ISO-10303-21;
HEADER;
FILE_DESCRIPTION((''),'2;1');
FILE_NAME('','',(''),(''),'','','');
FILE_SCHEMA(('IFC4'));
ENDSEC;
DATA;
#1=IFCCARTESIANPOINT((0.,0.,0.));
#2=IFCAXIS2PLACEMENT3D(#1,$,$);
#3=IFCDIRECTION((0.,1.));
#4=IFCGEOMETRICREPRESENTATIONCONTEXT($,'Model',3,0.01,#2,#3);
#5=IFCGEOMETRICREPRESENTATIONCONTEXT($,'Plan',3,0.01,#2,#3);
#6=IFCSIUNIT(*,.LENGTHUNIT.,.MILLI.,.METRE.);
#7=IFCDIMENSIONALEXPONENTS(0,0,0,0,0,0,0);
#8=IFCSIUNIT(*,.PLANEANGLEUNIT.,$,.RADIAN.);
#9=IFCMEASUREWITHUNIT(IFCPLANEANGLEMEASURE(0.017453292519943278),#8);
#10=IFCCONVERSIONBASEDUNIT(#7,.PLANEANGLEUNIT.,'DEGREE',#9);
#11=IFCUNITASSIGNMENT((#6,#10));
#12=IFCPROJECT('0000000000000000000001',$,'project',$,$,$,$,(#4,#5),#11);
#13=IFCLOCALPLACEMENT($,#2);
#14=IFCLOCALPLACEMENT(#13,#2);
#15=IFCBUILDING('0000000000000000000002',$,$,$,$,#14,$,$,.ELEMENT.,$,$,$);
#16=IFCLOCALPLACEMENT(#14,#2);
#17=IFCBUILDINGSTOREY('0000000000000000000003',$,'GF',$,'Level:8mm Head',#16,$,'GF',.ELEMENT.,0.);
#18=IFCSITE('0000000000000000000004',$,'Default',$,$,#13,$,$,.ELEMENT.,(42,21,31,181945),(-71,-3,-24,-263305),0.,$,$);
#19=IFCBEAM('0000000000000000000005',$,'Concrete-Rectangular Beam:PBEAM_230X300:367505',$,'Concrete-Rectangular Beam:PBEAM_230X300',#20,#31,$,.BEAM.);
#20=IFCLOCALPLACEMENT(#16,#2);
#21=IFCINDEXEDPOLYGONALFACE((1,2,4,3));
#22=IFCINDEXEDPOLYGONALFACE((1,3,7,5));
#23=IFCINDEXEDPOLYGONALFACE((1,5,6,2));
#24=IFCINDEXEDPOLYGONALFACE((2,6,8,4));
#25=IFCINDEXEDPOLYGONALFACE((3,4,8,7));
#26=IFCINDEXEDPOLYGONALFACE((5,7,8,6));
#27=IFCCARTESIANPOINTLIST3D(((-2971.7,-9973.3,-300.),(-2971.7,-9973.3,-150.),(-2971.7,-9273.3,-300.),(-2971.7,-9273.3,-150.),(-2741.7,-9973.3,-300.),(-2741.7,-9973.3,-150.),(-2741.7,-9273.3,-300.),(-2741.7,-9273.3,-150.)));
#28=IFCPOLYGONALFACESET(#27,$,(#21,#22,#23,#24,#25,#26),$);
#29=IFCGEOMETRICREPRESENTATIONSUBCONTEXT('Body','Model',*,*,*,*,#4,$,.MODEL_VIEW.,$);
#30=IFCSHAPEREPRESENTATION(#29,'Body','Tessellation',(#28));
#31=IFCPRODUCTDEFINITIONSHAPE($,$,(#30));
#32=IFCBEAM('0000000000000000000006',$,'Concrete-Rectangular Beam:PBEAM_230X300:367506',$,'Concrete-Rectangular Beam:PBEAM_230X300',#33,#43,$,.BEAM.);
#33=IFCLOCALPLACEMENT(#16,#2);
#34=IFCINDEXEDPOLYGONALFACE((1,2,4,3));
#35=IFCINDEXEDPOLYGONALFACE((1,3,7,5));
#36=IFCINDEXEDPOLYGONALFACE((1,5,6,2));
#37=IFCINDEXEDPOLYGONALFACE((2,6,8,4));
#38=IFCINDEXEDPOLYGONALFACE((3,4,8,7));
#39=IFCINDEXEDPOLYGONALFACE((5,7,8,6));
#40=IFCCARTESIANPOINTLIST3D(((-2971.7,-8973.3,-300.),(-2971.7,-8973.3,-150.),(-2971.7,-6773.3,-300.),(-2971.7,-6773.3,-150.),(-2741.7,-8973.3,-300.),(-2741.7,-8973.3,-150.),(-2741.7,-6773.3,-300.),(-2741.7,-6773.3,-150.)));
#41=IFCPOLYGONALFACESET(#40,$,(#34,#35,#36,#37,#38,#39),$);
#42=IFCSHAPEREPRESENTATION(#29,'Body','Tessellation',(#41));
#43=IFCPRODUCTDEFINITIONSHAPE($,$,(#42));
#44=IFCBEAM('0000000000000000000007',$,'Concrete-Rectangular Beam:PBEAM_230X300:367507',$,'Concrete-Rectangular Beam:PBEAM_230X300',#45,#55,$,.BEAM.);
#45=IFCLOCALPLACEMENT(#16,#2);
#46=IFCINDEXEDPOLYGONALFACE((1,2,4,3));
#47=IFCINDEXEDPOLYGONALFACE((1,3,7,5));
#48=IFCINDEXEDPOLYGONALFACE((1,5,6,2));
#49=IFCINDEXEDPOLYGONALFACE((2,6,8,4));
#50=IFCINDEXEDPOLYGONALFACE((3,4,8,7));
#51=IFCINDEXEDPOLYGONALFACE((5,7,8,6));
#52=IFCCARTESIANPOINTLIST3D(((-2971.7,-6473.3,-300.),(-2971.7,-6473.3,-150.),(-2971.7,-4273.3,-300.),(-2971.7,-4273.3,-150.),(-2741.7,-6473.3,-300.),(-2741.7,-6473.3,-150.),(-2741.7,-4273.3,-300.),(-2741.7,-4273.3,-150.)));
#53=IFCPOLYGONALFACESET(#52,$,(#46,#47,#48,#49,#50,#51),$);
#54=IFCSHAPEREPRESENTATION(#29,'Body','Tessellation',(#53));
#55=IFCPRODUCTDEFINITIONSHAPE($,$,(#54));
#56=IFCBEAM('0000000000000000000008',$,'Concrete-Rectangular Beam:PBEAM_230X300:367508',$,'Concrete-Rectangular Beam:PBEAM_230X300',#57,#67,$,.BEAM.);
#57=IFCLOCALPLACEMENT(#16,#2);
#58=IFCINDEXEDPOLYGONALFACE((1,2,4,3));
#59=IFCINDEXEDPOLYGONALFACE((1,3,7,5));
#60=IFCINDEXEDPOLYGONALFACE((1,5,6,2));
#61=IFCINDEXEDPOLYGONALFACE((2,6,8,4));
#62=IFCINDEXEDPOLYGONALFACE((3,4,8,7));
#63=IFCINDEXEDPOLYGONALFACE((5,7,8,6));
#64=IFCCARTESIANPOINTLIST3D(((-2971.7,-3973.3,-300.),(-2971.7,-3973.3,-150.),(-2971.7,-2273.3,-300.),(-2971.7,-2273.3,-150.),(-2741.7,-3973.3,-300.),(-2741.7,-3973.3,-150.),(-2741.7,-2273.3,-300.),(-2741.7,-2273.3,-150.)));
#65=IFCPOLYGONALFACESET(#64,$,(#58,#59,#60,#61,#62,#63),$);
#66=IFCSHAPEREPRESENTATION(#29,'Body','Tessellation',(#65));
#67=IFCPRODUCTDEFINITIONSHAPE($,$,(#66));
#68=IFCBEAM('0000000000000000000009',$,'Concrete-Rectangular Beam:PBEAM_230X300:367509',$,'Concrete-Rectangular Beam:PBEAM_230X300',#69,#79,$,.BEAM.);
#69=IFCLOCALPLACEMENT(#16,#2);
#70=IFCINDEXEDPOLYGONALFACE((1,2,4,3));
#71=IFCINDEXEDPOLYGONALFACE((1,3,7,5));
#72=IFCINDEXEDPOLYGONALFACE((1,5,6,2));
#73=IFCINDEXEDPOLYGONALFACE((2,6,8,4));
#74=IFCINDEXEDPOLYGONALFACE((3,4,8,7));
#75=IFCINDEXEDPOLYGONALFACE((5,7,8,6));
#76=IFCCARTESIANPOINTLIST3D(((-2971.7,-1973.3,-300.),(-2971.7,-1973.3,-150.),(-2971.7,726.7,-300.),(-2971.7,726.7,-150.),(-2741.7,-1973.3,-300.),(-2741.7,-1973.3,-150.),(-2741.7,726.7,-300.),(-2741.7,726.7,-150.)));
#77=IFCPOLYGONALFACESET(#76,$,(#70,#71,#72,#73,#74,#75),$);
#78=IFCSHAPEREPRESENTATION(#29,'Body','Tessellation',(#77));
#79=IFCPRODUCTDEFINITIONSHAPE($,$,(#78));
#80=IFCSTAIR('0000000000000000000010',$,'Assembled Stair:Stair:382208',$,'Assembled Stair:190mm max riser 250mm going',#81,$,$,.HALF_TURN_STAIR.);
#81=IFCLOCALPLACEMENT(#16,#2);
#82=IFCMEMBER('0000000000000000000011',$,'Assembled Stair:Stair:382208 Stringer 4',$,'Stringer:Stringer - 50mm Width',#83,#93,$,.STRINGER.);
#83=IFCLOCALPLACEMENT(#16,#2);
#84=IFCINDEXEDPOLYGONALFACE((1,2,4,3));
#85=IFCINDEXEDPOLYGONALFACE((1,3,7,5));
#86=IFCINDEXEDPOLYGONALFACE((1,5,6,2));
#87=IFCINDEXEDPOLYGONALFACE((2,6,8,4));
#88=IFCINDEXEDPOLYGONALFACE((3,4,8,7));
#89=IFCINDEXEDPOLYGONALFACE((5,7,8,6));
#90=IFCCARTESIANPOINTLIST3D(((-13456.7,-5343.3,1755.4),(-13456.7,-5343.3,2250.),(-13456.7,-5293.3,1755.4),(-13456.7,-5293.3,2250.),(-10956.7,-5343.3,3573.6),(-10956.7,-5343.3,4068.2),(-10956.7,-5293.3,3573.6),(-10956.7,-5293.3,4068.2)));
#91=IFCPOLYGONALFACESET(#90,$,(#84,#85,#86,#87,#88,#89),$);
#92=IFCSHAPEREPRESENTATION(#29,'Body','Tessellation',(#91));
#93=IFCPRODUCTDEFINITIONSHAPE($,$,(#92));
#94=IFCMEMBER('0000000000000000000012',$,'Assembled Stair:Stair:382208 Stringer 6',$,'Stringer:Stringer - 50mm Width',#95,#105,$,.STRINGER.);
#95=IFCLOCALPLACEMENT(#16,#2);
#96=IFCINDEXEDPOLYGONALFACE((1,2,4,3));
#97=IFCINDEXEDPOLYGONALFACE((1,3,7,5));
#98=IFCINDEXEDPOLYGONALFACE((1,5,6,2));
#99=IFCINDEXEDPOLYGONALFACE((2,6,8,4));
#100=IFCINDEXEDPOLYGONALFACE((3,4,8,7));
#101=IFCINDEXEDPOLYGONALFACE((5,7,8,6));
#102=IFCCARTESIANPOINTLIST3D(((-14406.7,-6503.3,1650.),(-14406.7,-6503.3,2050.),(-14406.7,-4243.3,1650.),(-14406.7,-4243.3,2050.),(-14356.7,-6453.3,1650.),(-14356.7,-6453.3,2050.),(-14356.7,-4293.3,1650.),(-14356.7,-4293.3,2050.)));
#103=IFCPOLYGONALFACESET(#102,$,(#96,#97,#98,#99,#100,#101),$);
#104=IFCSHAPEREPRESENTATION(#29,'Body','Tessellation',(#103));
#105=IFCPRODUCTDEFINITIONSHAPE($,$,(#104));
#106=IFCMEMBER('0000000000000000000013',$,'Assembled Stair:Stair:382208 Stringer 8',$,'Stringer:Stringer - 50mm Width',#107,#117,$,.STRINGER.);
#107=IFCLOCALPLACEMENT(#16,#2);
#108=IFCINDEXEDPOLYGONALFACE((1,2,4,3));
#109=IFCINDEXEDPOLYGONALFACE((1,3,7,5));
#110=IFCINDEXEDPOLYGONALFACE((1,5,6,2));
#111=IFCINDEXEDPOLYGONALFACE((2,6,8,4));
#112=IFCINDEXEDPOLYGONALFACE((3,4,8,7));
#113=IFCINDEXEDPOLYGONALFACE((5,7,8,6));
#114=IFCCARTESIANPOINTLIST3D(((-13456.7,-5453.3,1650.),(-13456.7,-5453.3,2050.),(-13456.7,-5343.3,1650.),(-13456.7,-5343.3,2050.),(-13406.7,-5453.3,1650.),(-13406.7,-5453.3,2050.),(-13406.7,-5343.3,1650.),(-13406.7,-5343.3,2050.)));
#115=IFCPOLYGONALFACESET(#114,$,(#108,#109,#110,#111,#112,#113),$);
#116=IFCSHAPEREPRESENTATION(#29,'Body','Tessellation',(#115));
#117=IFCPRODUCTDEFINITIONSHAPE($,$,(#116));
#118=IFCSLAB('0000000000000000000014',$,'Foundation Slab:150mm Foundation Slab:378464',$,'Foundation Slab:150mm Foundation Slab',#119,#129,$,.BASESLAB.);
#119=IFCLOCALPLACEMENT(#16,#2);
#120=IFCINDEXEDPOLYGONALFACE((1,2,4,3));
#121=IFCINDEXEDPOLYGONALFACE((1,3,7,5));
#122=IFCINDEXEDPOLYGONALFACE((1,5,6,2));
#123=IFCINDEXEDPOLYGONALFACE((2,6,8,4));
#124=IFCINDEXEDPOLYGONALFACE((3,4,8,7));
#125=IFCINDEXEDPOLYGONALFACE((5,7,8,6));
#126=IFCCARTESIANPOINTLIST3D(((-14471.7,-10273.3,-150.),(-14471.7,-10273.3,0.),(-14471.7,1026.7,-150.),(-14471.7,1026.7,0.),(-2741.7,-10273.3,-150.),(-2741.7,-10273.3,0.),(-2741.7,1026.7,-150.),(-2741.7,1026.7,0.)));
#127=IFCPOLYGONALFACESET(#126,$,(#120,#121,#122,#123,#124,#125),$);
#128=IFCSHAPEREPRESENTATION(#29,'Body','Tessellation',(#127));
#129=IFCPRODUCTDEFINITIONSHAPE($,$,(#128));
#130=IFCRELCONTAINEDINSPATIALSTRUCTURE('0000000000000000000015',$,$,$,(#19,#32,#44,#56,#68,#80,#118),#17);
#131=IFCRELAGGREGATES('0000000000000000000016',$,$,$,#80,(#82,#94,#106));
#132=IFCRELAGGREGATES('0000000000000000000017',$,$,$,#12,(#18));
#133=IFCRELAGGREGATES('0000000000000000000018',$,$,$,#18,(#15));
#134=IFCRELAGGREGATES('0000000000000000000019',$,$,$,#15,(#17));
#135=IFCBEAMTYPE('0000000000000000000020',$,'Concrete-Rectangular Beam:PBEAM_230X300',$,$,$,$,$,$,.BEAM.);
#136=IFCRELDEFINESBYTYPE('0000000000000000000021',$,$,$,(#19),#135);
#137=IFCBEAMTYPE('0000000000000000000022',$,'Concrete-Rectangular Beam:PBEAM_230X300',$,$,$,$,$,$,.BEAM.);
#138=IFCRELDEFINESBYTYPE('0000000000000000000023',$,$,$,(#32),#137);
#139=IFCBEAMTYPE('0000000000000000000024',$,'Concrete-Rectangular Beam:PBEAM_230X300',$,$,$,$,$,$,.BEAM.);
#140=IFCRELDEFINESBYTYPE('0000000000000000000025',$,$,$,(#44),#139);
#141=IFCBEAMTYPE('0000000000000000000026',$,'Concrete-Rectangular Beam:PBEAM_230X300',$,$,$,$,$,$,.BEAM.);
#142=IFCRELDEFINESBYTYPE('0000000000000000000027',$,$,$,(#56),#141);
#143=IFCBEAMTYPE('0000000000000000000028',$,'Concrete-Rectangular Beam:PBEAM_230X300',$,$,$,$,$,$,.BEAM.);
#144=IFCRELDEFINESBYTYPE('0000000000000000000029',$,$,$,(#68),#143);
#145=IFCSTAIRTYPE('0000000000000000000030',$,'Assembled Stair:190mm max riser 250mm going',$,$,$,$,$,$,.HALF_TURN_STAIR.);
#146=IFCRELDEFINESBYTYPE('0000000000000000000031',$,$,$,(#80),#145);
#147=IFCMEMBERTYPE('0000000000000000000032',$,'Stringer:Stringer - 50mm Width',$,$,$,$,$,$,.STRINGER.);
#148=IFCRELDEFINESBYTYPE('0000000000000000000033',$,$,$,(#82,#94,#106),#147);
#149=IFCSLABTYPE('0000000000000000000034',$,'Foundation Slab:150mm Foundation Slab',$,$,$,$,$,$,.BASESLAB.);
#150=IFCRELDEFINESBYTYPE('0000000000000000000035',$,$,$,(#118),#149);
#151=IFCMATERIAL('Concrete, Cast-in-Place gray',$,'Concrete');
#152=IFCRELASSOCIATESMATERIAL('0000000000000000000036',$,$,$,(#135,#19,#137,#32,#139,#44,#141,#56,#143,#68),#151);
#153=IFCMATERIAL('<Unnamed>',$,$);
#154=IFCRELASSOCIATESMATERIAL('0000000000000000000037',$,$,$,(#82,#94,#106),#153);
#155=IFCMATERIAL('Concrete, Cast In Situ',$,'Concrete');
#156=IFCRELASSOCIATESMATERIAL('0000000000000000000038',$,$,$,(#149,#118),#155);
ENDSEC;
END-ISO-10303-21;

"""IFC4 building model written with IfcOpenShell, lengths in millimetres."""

from ifc_helpers import new_model, entity, si_unit, converted_unit, direction, frame, origin, place, context, subcontext, project, spatial, indexed_curve, outline, extrude, source, transform, mapped, material, type_object, type_shapes, element, aggregate, save


model = new_model("IFC4")

# Units and contexts
model_context = context("Model", 3, precision=0.01, world=origin(), true_north=direction((0.0, 1.0)))
plan_context = context("Plan", 3, precision=0.01, world=origin(), true_north=direction((0.0, 1.0)))
body_context = subcontext(model_context, "Body", "Model", "MODEL_VIEW")
ifc_project = project(units=[si_unit("LENGTHUNIT", "METRE", prefix="MILLI"), converted_unit("PLANEANGLEUNIT", "DEGREE", entity("IfcPlaneAngleMeasure", 0.017453292519943278), si_unit("PLANEANGLEUNIT", "RADIAN"), dimensions=[0, 0, 0, 0, 0, 0, 0])], contexts=[model_context, plan_context])

# Site, building, storey
site_placement = place(None, origin())
site = spatial("IfcSite", under=ifc_project, at=site_placement, Name="Default", CompositionType="ELEMENT", RefLatitude=(42, 21, 31, 181945), RefLongitude=(-71, -3, -24, -263305), RefElevation=0.0)
building_placement = place(site_placement, origin())
building = spatial("IfcBuilding", under=site, at=building_placement, CompositionType="ELEMENT")
storey_placement = place(building_placement, origin())
storey = spatial("IfcBuildingStorey", under=building, at=storey_placement, Name="GF", ObjectType="Level:8mm Head", LongName="GF", CompositionType="ELEMENT", Elevation=0.0)

# Beams
ifc_material_1 = material(Name="Concrete, Cast-in-Place gray", Category="Concrete")
beam_type_1 = type_object("IfcBeamType", Name="Concrete-Rectangular Beam:PBEAM_230X300", PredefinedType="BEAM", material=ifc_material_1)
shared_shape_1 = source(origin(), body_context, "Body", "SweptSolid", [
    extrude(outline(indexed_curve([(-115.0, -75.0), (115.0, -75.0), (115.0, 75.0), (-115.0, 75.0), (-115.0, -75.0)], self_intersect=False)), frame((-2856.7, -9973.3, -225.0), z_axis=(0.0, 1.0, 0.0), x_axis=(-1.0, 0.0, 0.0)), (0.0, 0.0, 1.0), 700.0),
])
type_shapes(beam_type_1, [shared_shape_1])
beam_1_placement = place(storey_placement, origin())
element("IfcBeam", 1, at=beam_1_placement, inside=storey, type_object=beam_type_1, material=ifc_material_1, Name="Concrete-Rectangular Beam:PBEAM_230X300:367505", ObjectType="Concrete-Rectangular Beam:PBEAM_230X300", PredefinedType="BEAM", context=body_context, shape_type="MappedRepresentation", body=[
    mapped(shared_shape_1, transform((0.0, 0.0, 0.0), scale=1.0)),
])
beam_type_2 = type_object("IfcBeamType", Name="Concrete-Rectangular Beam:PBEAM_230X300", PredefinedType="BEAM", material=ifc_material_1)
shared_shape_2 = source(origin(), body_context, "Body", "SweptSolid", [
    extrude(outline(indexed_curve([(-115.0, -75.0), (115.0, -75.0), (115.0, 75.0), (-115.0, 75.0), (-115.0, -75.0)], self_intersect=False)), frame((-2856.7, -8973.3, -225.0), z_axis=(0.0, 1.0, 0.0), x_axis=(-1.0, 0.0, 0.0)), (0.0, 0.0, 1.0), 2200.0),
])
type_shapes(beam_type_2, [shared_shape_2])
beam_2_placement = place(storey_placement, origin())
element("IfcBeam", 2, at=beam_2_placement, inside=storey, type_object=beam_type_2, material=ifc_material_1, Name="Concrete-Rectangular Beam:PBEAM_230X300:367506", ObjectType="Concrete-Rectangular Beam:PBEAM_230X300", PredefinedType="BEAM", context=body_context, shape_type="MappedRepresentation", body=[
    mapped(shared_shape_2, transform((0.0, 0.0, 0.0), scale=1.0)),
])
beam_type_3 = type_object("IfcBeamType", Name="Concrete-Rectangular Beam:PBEAM_230X300", PredefinedType="BEAM", material=ifc_material_1)
shared_shape_3 = source(origin(), body_context, "Body", "SweptSolid", [
    extrude(outline(indexed_curve([(-115.0, -75.0), (115.0, -75.0), (115.0, 75.0), (-115.0, 75.0), (-115.0, -75.0)], self_intersect=False)), frame((-2856.7, -6473.3, -225.0), z_axis=(0.0, 1.0, 0.0), x_axis=(-1.0, 0.0, 0.0)), (0.0, 0.0, 1.0), 2200.0),
])
type_shapes(beam_type_3, [shared_shape_3])
beam_3_placement = place(storey_placement, origin())
element("IfcBeam", 3, at=beam_3_placement, inside=storey, type_object=beam_type_3, material=ifc_material_1, Name="Concrete-Rectangular Beam:PBEAM_230X300:367507", ObjectType="Concrete-Rectangular Beam:PBEAM_230X300", PredefinedType="BEAM", context=body_context, shape_type="MappedRepresentation", body=[
    mapped(shared_shape_3, transform((0.0, 0.0, 0.0), scale=1.0)),
])
beam_type_4 = type_object("IfcBeamType", Name="Concrete-Rectangular Beam:PBEAM_230X300", PredefinedType="BEAM", material=ifc_material_1)
shared_shape_4 = source(origin(), body_context, "Body", "SweptSolid", [
    extrude(outline(indexed_curve([(-115.0, -75.0), (115.0, -75.0), (115.0, 75.0), (-115.0, 75.0), (-115.0, -75.0)], self_intersect=False)), frame((-2856.7, -3973.3, -225.0), z_axis=(0.0, 1.0, 0.0), x_axis=(-1.0, 0.0, 0.0)), (0.0, 0.0, 1.0), 1700.0),
])
type_shapes(beam_type_4, [shared_shape_4])
beam_4_placement = place(storey_placement, origin())
element("IfcBeam", 4, at=beam_4_placement, inside=storey, type_object=beam_type_4, material=ifc_material_1, Name="Concrete-Rectangular Beam:PBEAM_230X300:367508", ObjectType="Concrete-Rectangular Beam:PBEAM_230X300", PredefinedType="BEAM", context=body_context, shape_type="MappedRepresentation", body=[
    mapped(shared_shape_4, transform((0.0, 0.0, 0.0), scale=1.0)),
])
beam_type_5 = type_object("IfcBeamType", Name="Concrete-Rectangular Beam:PBEAM_230X300", PredefinedType="BEAM", material=ifc_material_1)
shared_shape_5 = source(origin(), body_context, "Body", "SweptSolid", [
    extrude(outline(indexed_curve([(-115.0, -75.0), (115.0, -75.0), (115.0, 75.0), (-115.0, 75.0), (-115.0, -75.0)], self_intersect=False)), frame((-2856.7, -1973.3, -225.0), z_axis=(0.0, 1.0, 0.0), x_axis=(-1.0, 0.0, 0.0)), (0.0, 0.0, 1.0), 2700.0),
])
type_shapes(beam_type_5, [shared_shape_5])
beam_5_placement = place(storey_placement, origin())
element("IfcBeam", 5, at=beam_5_placement, inside=storey, type_object=beam_type_5, material=ifc_material_1, Name="Concrete-Rectangular Beam:PBEAM_230X300:367509", ObjectType="Concrete-Rectangular Beam:PBEAM_230X300", PredefinedType="BEAM", context=body_context, shape_type="MappedRepresentation", body=[
    mapped(shared_shape_5, transform((0.0, 0.0, 0.0), scale=1.0)),
])

# Stair, members
stair_type = type_object("IfcStairType", Name="Assembled Stair:190mm max riser 250mm going", PredefinedType="HALF_TURN_STAIR")
stair_placement = place(storey_placement, origin())
stair = element("IfcStair", 6, at=stair_placement, inside=storey, type_object=stair_type, Name="Assembled Stair:Stair:382208", ObjectType="Assembled Stair:190mm max riser 250mm going", PredefinedType="HALF_TURN_STAIR")
ifc_material_2 = material(Name="<Unnamed>")
member_type = type_object("IfcMemberType", Name="Stringer:Stringer - 50mm Width", PredefinedType="STRINGER")
member_1_placement = place(stair_placement, origin())
member_1 = element("IfcMember", 7, at=member_1_placement, type_object=member_type, material=ifc_material_2, Name="Assembled Stair:Stair:382208 Stringer 4", ObjectType="Stringer:Stringer - 50mm Width", PredefinedType="STRINGER", context=body_context, shape_type="SweptSolid", body=[
    extrude(outline(indexed_curve([(-1400.2, -200.0), (1691.1, -200.0), (1400.2, 200.0), (-1691.1, 200.0), (-1400.2, -200.0)], self_intersect=False)), frame((-12206.7, -5343.3, 2911.8), z_axis=(0.0, 1.0, 0.0), x_axis=(0.808736, 0.0, 0.588172)), (0.0, 0.0, 1.0), 50.0),
])
member_2_placement = place(stair_placement, origin())
member_2 = element("IfcMember", 8, at=member_2_placement, type_object=member_type, material=ifc_material_2, Name="Assembled Stair:Stair:382208 Stringer 6", ObjectType="Stringer:Stringer - 50mm Width", PredefinedType="STRINGER", context=body_context, shape_type="SweptSolid", body=[
    extrude(outline(indexed_curve([(-1130.0, -25.0), (1130.0, -25.0), (1080.0, 25.0), (-1080.0, 25.0), (-1130.0, -25.0)], self_intersect=False)), frame((-14381.7, -5373.3, 1650.0), z_axis=(0.0, 0.0, 1.0), x_axis=(0.0, -1.0, 0.0)), (0.0, 0.0, 1.0), 400.0),
])
member_3_placement = place(stair_placement, origin())
member_3 = element("IfcMember", 9, at=member_3_placement, type_object=member_type, material=ifc_material_2, Name="Assembled Stair:Stair:382208 Stringer 8", ObjectType="Stringer:Stringer - 50mm Width", PredefinedType="STRINGER", context=body_context, shape_type="SweptSolid", body=[
    extrude(outline(indexed_curve([(-55.0, -25.0), (55.0, -25.0), (55.0, 25.0), (-55.0, 25.0), (-55.0, -25.0)], self_intersect=False)), frame((-13431.7, -5398.3, 1650.0), z_axis=(0.0, 0.0, 1.0), x_axis=(0.0, 1.0, 0.0)), (0.0, 0.0, 1.0), 400.0),
])

# Slab
ifc_material_3 = material(Name="Concrete, Cast In Situ", Category="Concrete")
slab_type_1 = type_object("IfcSlabType", Name="Foundation Slab:150mm Foundation Slab", PredefinedType="BASESLAB", material=ifc_material_3)
slab_1_placement = place(storey_placement, origin())
element("IfcSlab", 10, at=slab_1_placement, inside=storey, type_object=slab_type_1, material=ifc_material_3, Name="Foundation Slab:150mm Foundation Slab:378464", ObjectType="Foundation Slab:150mm Foundation Slab", PredefinedType="BASESLAB", context=body_context, shape_type="SweptSolid", body=[
    extrude(outline(indexed_curve([(-5650.0, -5865.0), (5650.0, -5865.0), (5650.0, 5865.0), (-5650.0, 5865.0), (-5650.0, -5865.0)], self_intersect=False)), frame((-8606.7, -4623.3, 0.0), z_axis=(0.0, 0.0, -1.0), x_axis=(0.0, 1.0, 0.0)), (0.0, 0.0, 1.0), 150.0),
])

aggregate(stair, [member_1, member_2, member_3])

save(model, "model.ifc")
